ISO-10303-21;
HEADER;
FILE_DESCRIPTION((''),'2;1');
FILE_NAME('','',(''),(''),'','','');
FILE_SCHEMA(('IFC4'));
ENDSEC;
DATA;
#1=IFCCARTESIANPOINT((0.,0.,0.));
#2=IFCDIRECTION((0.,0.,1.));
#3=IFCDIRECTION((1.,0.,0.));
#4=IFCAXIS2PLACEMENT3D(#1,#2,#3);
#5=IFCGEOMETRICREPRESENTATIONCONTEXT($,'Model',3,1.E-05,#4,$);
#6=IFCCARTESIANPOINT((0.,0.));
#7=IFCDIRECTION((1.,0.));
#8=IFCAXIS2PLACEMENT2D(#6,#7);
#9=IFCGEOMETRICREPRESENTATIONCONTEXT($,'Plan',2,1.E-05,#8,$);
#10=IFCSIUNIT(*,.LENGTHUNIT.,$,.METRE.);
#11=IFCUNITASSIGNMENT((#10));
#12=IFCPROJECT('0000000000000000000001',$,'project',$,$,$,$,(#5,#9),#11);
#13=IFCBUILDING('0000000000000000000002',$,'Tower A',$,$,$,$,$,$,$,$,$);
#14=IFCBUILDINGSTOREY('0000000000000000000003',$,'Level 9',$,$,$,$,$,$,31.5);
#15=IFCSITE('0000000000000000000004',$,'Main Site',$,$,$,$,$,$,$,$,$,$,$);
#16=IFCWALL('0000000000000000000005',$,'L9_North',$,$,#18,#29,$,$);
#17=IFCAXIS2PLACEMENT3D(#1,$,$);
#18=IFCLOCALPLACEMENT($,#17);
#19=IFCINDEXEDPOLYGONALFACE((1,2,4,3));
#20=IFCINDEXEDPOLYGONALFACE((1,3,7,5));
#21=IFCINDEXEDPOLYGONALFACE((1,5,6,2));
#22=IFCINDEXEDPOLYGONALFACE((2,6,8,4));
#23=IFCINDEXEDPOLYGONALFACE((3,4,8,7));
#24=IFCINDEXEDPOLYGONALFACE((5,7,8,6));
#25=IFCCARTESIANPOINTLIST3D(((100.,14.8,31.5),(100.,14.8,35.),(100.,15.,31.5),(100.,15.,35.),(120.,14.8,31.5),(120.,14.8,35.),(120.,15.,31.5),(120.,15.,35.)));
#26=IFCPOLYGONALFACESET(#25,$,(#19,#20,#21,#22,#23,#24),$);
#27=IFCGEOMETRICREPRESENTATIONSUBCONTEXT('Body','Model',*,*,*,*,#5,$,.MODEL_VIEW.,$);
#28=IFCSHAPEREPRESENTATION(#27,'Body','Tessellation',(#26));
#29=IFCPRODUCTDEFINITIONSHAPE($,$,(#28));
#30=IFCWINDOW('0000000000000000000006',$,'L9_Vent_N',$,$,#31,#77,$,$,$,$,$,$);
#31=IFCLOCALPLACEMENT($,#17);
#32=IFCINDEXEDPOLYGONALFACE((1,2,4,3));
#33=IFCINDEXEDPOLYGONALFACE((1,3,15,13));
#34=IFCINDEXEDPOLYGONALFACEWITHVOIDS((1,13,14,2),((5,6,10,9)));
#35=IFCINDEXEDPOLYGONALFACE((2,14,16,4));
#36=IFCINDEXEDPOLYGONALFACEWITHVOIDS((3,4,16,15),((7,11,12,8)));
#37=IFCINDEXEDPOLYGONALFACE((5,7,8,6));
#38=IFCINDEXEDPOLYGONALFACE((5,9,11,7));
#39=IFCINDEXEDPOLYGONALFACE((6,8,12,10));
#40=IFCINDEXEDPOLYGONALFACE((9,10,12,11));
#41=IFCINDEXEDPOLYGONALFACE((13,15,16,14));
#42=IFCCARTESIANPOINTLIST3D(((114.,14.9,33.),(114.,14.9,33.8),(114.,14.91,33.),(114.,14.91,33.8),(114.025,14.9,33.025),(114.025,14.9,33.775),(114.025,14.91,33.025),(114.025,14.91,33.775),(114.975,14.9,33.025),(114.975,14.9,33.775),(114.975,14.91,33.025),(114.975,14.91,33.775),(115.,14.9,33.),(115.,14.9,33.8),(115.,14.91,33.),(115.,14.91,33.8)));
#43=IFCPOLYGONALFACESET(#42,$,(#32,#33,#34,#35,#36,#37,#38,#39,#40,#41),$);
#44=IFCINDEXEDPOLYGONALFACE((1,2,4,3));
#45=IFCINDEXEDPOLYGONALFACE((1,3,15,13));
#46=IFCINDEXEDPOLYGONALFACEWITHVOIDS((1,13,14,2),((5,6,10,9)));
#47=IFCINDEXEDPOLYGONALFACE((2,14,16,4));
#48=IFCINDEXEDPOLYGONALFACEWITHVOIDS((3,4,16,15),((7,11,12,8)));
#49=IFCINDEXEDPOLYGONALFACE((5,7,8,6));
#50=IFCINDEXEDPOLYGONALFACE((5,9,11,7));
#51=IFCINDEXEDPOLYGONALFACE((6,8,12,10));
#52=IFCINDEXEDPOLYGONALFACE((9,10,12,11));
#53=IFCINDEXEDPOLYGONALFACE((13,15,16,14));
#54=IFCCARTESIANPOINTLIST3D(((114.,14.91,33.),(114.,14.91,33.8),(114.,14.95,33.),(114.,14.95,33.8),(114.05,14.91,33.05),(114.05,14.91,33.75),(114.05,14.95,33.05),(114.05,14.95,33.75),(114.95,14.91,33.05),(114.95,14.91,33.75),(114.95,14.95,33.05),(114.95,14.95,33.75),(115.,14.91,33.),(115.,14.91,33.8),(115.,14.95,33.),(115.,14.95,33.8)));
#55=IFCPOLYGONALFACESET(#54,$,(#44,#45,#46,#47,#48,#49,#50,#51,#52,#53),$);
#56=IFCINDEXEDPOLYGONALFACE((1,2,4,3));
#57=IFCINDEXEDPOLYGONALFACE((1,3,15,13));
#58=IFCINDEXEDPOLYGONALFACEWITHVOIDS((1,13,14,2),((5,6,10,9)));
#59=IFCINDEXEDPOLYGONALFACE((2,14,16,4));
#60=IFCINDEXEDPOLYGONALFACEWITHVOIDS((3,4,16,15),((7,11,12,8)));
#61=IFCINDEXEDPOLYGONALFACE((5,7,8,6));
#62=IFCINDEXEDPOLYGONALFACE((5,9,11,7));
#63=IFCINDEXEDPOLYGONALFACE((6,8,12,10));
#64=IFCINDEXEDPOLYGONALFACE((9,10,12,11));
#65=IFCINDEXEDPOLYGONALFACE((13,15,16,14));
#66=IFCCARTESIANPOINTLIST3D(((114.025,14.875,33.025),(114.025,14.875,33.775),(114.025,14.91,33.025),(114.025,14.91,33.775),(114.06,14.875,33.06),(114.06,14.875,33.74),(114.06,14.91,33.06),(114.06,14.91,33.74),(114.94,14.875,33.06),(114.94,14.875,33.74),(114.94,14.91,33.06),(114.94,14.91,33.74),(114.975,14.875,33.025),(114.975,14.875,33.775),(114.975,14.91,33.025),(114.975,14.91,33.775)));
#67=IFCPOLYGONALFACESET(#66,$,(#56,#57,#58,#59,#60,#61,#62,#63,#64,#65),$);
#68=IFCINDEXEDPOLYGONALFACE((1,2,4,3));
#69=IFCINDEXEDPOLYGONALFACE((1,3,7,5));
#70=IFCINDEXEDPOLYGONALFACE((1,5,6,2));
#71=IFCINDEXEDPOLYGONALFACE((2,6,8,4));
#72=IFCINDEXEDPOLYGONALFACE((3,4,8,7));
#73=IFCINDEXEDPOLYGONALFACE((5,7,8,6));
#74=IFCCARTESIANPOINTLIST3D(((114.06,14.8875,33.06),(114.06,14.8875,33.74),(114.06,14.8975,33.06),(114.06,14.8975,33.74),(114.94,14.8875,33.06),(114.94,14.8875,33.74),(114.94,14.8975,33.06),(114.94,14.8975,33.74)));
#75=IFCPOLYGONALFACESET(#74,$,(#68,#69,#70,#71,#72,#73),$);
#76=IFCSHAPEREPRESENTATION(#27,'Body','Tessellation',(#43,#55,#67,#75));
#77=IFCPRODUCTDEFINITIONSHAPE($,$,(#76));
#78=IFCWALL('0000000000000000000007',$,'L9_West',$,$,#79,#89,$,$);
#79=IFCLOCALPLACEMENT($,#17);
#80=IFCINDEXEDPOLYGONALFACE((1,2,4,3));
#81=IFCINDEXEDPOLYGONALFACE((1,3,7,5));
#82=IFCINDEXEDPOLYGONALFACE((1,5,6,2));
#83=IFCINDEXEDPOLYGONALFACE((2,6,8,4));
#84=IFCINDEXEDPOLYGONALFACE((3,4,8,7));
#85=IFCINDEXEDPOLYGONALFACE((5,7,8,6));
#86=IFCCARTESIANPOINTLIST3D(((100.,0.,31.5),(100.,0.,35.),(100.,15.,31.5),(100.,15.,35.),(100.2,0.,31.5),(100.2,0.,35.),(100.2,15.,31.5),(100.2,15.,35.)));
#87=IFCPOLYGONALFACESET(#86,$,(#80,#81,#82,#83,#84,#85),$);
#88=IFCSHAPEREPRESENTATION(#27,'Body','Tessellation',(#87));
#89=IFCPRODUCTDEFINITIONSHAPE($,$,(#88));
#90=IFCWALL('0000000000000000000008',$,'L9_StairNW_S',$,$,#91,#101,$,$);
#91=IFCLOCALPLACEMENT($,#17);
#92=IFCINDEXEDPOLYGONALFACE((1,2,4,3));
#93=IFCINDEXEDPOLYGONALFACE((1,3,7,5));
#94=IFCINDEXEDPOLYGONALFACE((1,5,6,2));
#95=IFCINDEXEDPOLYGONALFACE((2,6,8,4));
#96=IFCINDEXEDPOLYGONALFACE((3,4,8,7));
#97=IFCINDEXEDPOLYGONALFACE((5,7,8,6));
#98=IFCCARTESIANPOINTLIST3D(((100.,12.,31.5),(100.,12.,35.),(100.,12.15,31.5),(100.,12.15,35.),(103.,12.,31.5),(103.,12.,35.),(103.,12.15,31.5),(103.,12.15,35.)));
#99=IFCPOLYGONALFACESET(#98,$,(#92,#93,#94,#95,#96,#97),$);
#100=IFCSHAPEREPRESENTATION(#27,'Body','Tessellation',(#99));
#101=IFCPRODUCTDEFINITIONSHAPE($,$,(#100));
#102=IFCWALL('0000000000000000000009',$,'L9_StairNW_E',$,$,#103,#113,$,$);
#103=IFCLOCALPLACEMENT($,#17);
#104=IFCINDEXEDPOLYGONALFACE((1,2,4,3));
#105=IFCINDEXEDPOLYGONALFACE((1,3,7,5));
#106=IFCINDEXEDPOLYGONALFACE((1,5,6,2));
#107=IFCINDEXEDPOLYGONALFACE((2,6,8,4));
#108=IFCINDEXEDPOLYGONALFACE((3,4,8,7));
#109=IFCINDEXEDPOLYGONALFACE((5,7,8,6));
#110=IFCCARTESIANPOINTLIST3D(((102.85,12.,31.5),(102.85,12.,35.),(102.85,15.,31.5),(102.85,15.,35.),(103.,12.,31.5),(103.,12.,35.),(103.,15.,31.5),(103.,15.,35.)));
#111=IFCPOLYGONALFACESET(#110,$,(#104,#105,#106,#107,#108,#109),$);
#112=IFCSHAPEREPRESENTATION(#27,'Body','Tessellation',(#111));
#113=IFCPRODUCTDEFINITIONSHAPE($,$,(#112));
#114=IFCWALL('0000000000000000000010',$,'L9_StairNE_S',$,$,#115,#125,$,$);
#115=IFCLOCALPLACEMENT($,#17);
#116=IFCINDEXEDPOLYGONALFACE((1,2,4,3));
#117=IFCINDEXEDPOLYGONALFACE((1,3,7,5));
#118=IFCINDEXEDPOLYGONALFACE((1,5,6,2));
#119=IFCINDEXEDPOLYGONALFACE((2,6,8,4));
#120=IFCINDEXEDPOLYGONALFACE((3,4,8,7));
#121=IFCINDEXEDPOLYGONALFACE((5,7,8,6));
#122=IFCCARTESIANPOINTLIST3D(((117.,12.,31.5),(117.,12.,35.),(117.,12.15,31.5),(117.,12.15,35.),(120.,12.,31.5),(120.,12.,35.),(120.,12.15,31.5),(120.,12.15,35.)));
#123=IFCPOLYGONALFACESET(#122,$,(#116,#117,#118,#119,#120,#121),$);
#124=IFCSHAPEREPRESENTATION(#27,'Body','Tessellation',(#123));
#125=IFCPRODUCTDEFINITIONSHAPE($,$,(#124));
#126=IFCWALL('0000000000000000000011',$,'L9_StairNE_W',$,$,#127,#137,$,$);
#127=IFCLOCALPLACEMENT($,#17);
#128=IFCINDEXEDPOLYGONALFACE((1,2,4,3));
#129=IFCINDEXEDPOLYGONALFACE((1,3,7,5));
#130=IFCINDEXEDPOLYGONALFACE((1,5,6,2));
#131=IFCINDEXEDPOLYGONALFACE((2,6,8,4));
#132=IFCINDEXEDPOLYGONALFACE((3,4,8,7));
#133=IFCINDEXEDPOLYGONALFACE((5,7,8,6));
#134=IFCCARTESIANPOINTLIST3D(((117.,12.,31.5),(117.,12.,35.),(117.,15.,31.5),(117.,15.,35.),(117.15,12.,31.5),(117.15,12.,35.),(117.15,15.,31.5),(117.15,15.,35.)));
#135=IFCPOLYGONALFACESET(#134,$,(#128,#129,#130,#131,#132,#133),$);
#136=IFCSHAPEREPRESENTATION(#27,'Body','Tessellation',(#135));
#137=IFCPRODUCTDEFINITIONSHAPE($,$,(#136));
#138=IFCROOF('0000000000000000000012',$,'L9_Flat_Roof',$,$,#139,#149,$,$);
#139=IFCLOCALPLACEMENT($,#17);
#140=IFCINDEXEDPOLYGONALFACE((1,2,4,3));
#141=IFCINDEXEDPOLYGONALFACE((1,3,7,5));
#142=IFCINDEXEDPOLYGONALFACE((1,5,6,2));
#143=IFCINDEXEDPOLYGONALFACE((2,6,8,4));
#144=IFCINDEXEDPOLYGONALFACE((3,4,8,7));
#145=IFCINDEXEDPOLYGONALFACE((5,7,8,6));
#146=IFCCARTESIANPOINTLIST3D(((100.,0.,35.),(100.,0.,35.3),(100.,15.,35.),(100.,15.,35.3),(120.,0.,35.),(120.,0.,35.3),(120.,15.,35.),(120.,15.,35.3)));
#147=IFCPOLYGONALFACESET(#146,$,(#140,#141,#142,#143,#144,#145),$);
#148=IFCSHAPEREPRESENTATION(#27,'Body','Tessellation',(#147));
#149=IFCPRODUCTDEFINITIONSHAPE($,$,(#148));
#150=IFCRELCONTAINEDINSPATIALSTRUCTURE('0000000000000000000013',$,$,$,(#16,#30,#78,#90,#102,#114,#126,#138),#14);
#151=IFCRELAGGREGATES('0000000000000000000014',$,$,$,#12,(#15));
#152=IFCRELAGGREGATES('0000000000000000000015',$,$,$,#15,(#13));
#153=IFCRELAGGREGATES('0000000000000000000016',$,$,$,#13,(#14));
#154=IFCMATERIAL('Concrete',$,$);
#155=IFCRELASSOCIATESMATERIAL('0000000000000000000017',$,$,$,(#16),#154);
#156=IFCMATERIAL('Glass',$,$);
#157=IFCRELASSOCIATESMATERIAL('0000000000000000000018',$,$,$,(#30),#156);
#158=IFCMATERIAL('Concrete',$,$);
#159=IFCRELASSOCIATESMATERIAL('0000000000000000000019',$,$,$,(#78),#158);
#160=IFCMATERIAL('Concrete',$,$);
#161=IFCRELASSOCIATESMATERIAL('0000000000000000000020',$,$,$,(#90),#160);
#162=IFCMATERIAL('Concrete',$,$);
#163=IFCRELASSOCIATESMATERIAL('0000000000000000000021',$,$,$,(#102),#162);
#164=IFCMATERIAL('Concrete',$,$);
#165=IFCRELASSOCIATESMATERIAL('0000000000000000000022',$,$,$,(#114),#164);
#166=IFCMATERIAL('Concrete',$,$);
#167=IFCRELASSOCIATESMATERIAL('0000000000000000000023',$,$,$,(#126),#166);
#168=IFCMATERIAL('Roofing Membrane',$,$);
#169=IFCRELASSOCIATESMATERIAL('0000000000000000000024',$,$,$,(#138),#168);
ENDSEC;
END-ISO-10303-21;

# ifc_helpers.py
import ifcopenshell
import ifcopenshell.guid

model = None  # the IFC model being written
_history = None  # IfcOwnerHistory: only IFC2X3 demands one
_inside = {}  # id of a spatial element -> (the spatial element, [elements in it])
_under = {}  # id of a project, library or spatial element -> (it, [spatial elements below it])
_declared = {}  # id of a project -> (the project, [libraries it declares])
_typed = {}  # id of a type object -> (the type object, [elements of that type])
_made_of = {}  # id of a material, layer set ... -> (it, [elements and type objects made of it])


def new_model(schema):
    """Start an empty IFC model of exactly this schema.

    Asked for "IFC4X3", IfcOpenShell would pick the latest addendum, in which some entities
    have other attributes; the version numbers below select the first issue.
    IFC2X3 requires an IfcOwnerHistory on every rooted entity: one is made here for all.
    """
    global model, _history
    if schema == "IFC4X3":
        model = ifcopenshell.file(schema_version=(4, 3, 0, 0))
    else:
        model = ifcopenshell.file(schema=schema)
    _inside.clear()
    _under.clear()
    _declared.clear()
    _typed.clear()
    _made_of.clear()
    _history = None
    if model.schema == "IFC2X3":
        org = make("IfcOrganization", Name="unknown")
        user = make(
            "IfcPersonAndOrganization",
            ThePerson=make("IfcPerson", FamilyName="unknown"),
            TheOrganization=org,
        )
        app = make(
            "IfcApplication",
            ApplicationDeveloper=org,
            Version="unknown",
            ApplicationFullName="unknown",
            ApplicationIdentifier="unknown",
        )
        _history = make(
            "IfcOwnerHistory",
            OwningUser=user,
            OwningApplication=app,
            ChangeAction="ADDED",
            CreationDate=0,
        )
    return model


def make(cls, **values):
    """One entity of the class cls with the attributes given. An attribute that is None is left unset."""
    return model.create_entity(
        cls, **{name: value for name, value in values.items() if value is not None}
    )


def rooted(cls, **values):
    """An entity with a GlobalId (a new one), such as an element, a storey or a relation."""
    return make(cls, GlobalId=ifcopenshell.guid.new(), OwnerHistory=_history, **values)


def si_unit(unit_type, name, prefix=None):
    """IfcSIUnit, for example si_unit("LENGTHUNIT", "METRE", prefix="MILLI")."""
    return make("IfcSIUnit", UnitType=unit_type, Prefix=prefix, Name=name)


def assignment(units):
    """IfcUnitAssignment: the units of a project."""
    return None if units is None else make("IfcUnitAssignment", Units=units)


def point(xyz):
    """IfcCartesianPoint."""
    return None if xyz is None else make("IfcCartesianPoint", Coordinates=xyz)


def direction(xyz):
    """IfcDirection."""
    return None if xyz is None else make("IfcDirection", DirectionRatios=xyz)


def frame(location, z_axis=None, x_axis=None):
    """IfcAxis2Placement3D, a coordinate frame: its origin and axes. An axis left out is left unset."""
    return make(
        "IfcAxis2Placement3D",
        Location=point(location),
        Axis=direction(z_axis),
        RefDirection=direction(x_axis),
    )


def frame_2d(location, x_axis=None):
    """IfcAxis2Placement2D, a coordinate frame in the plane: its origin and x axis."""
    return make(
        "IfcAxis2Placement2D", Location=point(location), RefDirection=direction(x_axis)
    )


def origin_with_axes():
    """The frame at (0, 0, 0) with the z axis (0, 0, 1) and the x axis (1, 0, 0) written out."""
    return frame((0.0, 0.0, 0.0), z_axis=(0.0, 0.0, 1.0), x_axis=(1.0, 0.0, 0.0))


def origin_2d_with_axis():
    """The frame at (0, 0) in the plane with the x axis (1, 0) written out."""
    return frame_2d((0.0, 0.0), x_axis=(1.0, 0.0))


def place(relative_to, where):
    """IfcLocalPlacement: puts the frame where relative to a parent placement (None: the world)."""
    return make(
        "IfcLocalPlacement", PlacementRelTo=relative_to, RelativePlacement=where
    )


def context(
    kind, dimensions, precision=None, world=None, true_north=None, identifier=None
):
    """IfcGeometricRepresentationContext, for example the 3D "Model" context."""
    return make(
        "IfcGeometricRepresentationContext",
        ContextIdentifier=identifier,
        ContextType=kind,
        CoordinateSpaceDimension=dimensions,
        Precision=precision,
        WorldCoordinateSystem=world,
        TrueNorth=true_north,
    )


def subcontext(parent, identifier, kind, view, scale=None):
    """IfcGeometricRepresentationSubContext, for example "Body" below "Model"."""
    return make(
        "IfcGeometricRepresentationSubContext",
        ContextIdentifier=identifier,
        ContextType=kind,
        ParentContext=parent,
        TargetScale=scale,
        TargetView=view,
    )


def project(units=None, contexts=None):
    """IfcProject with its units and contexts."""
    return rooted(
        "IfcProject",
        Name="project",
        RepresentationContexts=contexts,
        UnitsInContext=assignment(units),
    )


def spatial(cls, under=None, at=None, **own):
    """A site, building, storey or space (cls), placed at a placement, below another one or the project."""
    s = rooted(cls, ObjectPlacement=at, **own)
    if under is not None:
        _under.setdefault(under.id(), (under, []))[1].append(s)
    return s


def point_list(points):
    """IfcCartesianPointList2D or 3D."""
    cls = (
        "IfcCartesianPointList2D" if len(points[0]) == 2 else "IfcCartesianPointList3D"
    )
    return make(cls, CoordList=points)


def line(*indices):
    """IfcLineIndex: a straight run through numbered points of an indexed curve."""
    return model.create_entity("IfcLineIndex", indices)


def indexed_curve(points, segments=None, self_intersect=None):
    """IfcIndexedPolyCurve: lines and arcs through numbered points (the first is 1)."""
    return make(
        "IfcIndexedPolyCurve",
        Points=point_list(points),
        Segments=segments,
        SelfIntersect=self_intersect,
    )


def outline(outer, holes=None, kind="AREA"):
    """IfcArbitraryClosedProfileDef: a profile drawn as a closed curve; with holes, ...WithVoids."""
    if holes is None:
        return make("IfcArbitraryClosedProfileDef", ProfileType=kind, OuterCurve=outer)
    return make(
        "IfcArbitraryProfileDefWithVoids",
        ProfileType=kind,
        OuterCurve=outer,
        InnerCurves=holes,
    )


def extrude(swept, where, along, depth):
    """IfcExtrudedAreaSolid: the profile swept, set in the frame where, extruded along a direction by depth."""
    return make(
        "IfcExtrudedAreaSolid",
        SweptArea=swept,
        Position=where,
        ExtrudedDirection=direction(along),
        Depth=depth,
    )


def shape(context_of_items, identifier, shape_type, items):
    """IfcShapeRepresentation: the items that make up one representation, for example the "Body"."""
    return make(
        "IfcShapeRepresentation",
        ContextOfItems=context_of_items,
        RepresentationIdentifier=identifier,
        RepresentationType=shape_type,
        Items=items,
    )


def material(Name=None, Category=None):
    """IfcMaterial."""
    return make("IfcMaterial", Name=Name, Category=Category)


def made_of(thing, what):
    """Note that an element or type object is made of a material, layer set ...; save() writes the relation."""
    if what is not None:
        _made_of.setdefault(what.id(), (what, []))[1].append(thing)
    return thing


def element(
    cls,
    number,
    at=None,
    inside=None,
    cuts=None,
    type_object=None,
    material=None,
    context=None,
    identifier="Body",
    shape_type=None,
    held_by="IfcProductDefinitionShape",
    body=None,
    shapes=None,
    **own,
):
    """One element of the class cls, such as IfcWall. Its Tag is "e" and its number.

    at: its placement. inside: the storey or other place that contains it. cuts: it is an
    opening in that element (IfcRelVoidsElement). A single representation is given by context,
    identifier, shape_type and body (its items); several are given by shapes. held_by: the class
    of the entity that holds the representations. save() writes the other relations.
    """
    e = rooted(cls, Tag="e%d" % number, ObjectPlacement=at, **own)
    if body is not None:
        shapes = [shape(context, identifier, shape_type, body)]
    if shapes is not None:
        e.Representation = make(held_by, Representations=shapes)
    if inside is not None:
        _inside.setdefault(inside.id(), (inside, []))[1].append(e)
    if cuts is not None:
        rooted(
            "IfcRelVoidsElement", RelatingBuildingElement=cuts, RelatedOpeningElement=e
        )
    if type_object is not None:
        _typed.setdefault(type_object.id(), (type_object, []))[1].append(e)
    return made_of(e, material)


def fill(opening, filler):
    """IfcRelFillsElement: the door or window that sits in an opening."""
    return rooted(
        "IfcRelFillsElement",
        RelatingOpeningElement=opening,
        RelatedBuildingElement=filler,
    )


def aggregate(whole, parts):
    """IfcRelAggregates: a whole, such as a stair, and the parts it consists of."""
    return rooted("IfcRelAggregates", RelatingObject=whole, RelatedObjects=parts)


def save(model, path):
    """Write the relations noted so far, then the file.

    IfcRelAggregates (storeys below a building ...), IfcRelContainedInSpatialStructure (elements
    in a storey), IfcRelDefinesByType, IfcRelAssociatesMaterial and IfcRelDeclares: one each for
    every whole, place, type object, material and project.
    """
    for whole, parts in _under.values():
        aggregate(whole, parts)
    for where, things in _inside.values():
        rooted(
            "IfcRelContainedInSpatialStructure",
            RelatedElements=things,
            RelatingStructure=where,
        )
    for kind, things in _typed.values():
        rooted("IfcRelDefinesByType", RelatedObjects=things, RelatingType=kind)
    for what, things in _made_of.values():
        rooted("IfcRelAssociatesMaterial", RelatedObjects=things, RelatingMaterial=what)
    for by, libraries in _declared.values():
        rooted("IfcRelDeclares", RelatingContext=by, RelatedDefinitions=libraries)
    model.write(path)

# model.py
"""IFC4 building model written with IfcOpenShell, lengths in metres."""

from ifc_helpers import new_model, si_unit, frame, origin_with_axes, origin_2d_with_axis, place, context, subcontext, project, spatial, line, indexed_curve, outline, extrude, material, element, fill, save


model = new_model("IFC4")

# Units and contexts
model_context = context("Model", 3, precision=1e-05, world=origin_with_axes())
plan_context = context("Plan", 2, precision=1e-05, world=origin_2d_with_axis())
body_context = subcontext(model_context, "Body", "Model", "MODEL_VIEW")
ifc_project = project(units=[si_unit("LENGTHUNIT", "METRE")], contexts=[model_context, plan_context])

# Site, building, storey
site = spatial("IfcSite", under=ifc_project, Name="Main Site")
building = spatial("IfcBuilding", under=site, Name="Tower A")
storey = spatial("IfcBuildingStorey", under=building, Name="Level 9", Elevation=31.5)

# Wall, opening, window
ifc_material_1 = material(Name="Concrete")
wall_1_placement = place(None, frame((120.0, 15.0, 31.5), z_axis=(0.0, 0.0, 1.0), x_axis=(-1.0, 0.0, 0.0)))
wall_1 = element("IfcWall", 1, at=wall_1_placement, inside=storey, material=ifc_material_1, Name="L9_North", context=body_context, shape_type="SweptSolid", body=[
    extrude(outline(indexed_curve([(0.0, 0.0), (0.0, 0.2), (20.0, 0.2), (20.0, 0.0), (0.0, 0.0)], self_intersect=False)), origin_with_axes(), (0.0, 0.0, 1.0), 3.5),
])
opening_1_placement = place(wall_1_placement, frame((5.0, 0.0, 1.5), z_axis=(0.0, 0.0, 1.0), x_axis=(-1.0, 0.0, 0.0)))
opening_1 = element("IfcOpeningElement", 2, at=opening_1_placement, cuts=wall_1, context=body_context, shape_type="SweptSolid", body=[
    extrude(outline(indexed_curve([(0.0, 0.0), (0.0, 0.25), (1.0, 0.25), (1.0, 0.0), (0.0, 0.0)], self_intersect=False)), origin_with_axes(), (0.0, 0.0, 1.0), 0.8),
])
ifc_material_2 = material(Name="Glass")
window_1_placement = place(None, frame((115.0, 15.0, 33.0), z_axis=(0.0, 0.0, 1.0), x_axis=(-1.0, 0.0, 0.0)))
window_1 = element("IfcWindow", 3, at=window_1_placement, inside=storey, material=ifc_material_2, Name="L9_Vent_N", context=body_context, shape_type="SweptSolid", body=[
    extrude(outline(indexed_curve([(0.0, 0.0), (1.0, 0.0), (1.0, 0.8), (0.0, 0.8)], segments=[line(1, 2, 3, 4, 1)]), holes=[indexed_curve([(0.025, 0.025), (0.975, 0.025), (0.975, 0.775), (0.025, 0.775)], segments=[line(1, 2, 3, 4, 1)])]), frame((0.0, 0.09, 0.0), z_axis=(0.0, -1.0, 0.0), x_axis=(1.0, 0.0, 0.0)), (0.0, 0.0, -1.0), 0.01),
    extrude(outline(indexed_curve([(0.0, 0.0), (1.0, 0.0), (1.0, 0.8), (0.0, 0.8)], segments=[line(1, 2, 3, 4, 1)]), holes=[indexed_curve([(0.05, 0.05), (0.95, 0.05), (0.95, 0.75), (0.05, 0.75)], segments=[line(1, 2, 3, 4, 1)])]), frame((0.0, 0.05, 0.0), z_axis=(0.0, -1.0, 0.0), x_axis=(1.0, 0.0, 0.0)), (0.0, 0.0, -1.0), 0.04),
    extrude(outline(indexed_curve([(0.0, 0.0), (0.95, 0.0), (0.95, 0.75), (0.0, 0.75)], segments=[line(1, 2, 3, 4, 1)]), holes=[indexed_curve([(0.035, 0.035), (0.915, 0.035), (0.915, 0.715), (0.035, 0.715)], segments=[line(1, 2, 3, 4, 1)])]), frame((0.025, 0.09, 0.025), z_axis=(0.0, -1.0, 0.0), x_axis=(1.0, 0.0, 0.0)), (0.0, 0.0, -1.0), 0.035),
    extrude(outline(indexed_curve([(0.035, 0.035), (0.915, 0.035), (0.915, 0.715), (0.035, 0.715)], segments=[line(1, 2, 3, 4, 1)])), frame((0.025, 0.1025, 0.025), z_axis=(0.0, -1.0, 0.0), x_axis=(1.0, 0.0, 0.0)), (0.0, 0.0, -1.0), 0.01),
])
fill(opening_1, window_1)

# Walls
ifc_material_3 = material(Name="Concrete")
wall_2_placement = place(None, frame((100.0, 15.0, 31.5), z_axis=(0.0, 0.0, 1.0), x_axis=(0.0, -1.0, 0.0)))
element("IfcWall", 4, at=wall_2_placement, inside=storey, material=ifc_material_3, Name="L9_West", context=body_context, shape_type="SweptSolid", body=[
    extrude(outline(indexed_curve([(0.0, 0.0), (0.0, 0.2), (15.0, 0.2), (15.0, 0.0), (0.0, 0.0)], self_intersect=False)), origin_with_axes(), (0.0, 0.0, 1.0), 3.5),
])
ifc_material_4 = material(Name="Concrete")
wall_3_placement = place(None, frame((100.0, 12.0, 31.5), z_axis=(0.0, 0.0, 1.0), x_axis=(1.0, 0.0, 0.0)))
element("IfcWall", 5, at=wall_3_placement, inside=storey, material=ifc_material_4, Name="L9_StairNW_S", context=body_context, shape_type="SweptSolid", body=[
    extrude(outline(indexed_curve([(0.0, 0.0), (0.0, 0.15), (3.0, 0.15), (3.0, 0.0), (0.0, 0.0)], self_intersect=False)), origin_with_axes(), (0.0, 0.0, 1.0), 3.5),
])
ifc_material_5 = material(Name="Concrete")
wall_4_placement = place(None, frame((103.0, 12.0, 31.5), z_axis=(0.0, 0.0, 1.0), x_axis=(0.0, 1.0, 0.0)))
element("IfcWall", 6, at=wall_4_placement, inside=storey, material=ifc_material_5, Name="L9_StairNW_E", context=body_context, shape_type="SweptSolid", body=[
    extrude(outline(indexed_curve([(0.0, 0.0), (0.0, 0.15), (3.0, 0.15), (3.0, 0.0), (0.0, 0.0)], self_intersect=False)), origin_with_axes(), (0.0, 0.0, 1.0), 3.5),
])
ifc_material_6 = material(Name="Concrete")
wall_5_placement = place(None, frame((117.0, 12.0, 31.5), z_axis=(0.0, 0.0, 1.0), x_axis=(1.0, 0.0, 0.0)))
element("IfcWall", 7, at=wall_5_placement, inside=storey, material=ifc_material_6, Name="L9_StairNE_S", context=body_context, shape_type="SweptSolid", body=[
    extrude(outline(indexed_curve([(0.0, 0.0), (0.0, 0.15), (3.0, 0.15), (3.0, 0.0), (0.0, 0.0)], self_intersect=False)), origin_with_axes(), (0.0, 0.0, 1.0), 3.5),
])
ifc_material_7 = material(Name="Concrete")
wall_6_placement = place(None, frame((117.0, 15.0, 31.5), z_axis=(0.0, 0.0, 1.0), x_axis=(0.0, -1.0, 0.0)))
element("IfcWall", 8, at=wall_6_placement, inside=storey, material=ifc_material_7, Name="L9_StairNE_W", context=body_context, shape_type="SweptSolid", body=[
    extrude(outline(indexed_curve([(0.0, 0.0), (0.0, 0.15), (3.0, 0.15), (3.0, 0.0), (0.0, 0.0)], self_intersect=False)), origin_with_axes(), (0.0, 0.0, 1.0), 3.5),
])

# Roof
ifc_material_8 = material(Name="Roofing Membrane")
roof_placement = place(None, frame((100.0, 0.0, 35.0), z_axis=(0.0, 0.0, 1.0), x_axis=(1.0, 0.0, 0.0)))
element("IfcRoof", 9, at=roof_placement, inside=storey, material=ifc_material_8, Name="L9_Flat_Roof", context=body_context, shape_type="SweptSolid", body=[
    extrude(outline(indexed_curve([(0.0, 0.0), (20.0, 0.0), (20.0, 15.0), (0.0, 15.0)])), None, (0.0, 0.0, 1.0), 0.3),
])

save(model, "model.ifc")
